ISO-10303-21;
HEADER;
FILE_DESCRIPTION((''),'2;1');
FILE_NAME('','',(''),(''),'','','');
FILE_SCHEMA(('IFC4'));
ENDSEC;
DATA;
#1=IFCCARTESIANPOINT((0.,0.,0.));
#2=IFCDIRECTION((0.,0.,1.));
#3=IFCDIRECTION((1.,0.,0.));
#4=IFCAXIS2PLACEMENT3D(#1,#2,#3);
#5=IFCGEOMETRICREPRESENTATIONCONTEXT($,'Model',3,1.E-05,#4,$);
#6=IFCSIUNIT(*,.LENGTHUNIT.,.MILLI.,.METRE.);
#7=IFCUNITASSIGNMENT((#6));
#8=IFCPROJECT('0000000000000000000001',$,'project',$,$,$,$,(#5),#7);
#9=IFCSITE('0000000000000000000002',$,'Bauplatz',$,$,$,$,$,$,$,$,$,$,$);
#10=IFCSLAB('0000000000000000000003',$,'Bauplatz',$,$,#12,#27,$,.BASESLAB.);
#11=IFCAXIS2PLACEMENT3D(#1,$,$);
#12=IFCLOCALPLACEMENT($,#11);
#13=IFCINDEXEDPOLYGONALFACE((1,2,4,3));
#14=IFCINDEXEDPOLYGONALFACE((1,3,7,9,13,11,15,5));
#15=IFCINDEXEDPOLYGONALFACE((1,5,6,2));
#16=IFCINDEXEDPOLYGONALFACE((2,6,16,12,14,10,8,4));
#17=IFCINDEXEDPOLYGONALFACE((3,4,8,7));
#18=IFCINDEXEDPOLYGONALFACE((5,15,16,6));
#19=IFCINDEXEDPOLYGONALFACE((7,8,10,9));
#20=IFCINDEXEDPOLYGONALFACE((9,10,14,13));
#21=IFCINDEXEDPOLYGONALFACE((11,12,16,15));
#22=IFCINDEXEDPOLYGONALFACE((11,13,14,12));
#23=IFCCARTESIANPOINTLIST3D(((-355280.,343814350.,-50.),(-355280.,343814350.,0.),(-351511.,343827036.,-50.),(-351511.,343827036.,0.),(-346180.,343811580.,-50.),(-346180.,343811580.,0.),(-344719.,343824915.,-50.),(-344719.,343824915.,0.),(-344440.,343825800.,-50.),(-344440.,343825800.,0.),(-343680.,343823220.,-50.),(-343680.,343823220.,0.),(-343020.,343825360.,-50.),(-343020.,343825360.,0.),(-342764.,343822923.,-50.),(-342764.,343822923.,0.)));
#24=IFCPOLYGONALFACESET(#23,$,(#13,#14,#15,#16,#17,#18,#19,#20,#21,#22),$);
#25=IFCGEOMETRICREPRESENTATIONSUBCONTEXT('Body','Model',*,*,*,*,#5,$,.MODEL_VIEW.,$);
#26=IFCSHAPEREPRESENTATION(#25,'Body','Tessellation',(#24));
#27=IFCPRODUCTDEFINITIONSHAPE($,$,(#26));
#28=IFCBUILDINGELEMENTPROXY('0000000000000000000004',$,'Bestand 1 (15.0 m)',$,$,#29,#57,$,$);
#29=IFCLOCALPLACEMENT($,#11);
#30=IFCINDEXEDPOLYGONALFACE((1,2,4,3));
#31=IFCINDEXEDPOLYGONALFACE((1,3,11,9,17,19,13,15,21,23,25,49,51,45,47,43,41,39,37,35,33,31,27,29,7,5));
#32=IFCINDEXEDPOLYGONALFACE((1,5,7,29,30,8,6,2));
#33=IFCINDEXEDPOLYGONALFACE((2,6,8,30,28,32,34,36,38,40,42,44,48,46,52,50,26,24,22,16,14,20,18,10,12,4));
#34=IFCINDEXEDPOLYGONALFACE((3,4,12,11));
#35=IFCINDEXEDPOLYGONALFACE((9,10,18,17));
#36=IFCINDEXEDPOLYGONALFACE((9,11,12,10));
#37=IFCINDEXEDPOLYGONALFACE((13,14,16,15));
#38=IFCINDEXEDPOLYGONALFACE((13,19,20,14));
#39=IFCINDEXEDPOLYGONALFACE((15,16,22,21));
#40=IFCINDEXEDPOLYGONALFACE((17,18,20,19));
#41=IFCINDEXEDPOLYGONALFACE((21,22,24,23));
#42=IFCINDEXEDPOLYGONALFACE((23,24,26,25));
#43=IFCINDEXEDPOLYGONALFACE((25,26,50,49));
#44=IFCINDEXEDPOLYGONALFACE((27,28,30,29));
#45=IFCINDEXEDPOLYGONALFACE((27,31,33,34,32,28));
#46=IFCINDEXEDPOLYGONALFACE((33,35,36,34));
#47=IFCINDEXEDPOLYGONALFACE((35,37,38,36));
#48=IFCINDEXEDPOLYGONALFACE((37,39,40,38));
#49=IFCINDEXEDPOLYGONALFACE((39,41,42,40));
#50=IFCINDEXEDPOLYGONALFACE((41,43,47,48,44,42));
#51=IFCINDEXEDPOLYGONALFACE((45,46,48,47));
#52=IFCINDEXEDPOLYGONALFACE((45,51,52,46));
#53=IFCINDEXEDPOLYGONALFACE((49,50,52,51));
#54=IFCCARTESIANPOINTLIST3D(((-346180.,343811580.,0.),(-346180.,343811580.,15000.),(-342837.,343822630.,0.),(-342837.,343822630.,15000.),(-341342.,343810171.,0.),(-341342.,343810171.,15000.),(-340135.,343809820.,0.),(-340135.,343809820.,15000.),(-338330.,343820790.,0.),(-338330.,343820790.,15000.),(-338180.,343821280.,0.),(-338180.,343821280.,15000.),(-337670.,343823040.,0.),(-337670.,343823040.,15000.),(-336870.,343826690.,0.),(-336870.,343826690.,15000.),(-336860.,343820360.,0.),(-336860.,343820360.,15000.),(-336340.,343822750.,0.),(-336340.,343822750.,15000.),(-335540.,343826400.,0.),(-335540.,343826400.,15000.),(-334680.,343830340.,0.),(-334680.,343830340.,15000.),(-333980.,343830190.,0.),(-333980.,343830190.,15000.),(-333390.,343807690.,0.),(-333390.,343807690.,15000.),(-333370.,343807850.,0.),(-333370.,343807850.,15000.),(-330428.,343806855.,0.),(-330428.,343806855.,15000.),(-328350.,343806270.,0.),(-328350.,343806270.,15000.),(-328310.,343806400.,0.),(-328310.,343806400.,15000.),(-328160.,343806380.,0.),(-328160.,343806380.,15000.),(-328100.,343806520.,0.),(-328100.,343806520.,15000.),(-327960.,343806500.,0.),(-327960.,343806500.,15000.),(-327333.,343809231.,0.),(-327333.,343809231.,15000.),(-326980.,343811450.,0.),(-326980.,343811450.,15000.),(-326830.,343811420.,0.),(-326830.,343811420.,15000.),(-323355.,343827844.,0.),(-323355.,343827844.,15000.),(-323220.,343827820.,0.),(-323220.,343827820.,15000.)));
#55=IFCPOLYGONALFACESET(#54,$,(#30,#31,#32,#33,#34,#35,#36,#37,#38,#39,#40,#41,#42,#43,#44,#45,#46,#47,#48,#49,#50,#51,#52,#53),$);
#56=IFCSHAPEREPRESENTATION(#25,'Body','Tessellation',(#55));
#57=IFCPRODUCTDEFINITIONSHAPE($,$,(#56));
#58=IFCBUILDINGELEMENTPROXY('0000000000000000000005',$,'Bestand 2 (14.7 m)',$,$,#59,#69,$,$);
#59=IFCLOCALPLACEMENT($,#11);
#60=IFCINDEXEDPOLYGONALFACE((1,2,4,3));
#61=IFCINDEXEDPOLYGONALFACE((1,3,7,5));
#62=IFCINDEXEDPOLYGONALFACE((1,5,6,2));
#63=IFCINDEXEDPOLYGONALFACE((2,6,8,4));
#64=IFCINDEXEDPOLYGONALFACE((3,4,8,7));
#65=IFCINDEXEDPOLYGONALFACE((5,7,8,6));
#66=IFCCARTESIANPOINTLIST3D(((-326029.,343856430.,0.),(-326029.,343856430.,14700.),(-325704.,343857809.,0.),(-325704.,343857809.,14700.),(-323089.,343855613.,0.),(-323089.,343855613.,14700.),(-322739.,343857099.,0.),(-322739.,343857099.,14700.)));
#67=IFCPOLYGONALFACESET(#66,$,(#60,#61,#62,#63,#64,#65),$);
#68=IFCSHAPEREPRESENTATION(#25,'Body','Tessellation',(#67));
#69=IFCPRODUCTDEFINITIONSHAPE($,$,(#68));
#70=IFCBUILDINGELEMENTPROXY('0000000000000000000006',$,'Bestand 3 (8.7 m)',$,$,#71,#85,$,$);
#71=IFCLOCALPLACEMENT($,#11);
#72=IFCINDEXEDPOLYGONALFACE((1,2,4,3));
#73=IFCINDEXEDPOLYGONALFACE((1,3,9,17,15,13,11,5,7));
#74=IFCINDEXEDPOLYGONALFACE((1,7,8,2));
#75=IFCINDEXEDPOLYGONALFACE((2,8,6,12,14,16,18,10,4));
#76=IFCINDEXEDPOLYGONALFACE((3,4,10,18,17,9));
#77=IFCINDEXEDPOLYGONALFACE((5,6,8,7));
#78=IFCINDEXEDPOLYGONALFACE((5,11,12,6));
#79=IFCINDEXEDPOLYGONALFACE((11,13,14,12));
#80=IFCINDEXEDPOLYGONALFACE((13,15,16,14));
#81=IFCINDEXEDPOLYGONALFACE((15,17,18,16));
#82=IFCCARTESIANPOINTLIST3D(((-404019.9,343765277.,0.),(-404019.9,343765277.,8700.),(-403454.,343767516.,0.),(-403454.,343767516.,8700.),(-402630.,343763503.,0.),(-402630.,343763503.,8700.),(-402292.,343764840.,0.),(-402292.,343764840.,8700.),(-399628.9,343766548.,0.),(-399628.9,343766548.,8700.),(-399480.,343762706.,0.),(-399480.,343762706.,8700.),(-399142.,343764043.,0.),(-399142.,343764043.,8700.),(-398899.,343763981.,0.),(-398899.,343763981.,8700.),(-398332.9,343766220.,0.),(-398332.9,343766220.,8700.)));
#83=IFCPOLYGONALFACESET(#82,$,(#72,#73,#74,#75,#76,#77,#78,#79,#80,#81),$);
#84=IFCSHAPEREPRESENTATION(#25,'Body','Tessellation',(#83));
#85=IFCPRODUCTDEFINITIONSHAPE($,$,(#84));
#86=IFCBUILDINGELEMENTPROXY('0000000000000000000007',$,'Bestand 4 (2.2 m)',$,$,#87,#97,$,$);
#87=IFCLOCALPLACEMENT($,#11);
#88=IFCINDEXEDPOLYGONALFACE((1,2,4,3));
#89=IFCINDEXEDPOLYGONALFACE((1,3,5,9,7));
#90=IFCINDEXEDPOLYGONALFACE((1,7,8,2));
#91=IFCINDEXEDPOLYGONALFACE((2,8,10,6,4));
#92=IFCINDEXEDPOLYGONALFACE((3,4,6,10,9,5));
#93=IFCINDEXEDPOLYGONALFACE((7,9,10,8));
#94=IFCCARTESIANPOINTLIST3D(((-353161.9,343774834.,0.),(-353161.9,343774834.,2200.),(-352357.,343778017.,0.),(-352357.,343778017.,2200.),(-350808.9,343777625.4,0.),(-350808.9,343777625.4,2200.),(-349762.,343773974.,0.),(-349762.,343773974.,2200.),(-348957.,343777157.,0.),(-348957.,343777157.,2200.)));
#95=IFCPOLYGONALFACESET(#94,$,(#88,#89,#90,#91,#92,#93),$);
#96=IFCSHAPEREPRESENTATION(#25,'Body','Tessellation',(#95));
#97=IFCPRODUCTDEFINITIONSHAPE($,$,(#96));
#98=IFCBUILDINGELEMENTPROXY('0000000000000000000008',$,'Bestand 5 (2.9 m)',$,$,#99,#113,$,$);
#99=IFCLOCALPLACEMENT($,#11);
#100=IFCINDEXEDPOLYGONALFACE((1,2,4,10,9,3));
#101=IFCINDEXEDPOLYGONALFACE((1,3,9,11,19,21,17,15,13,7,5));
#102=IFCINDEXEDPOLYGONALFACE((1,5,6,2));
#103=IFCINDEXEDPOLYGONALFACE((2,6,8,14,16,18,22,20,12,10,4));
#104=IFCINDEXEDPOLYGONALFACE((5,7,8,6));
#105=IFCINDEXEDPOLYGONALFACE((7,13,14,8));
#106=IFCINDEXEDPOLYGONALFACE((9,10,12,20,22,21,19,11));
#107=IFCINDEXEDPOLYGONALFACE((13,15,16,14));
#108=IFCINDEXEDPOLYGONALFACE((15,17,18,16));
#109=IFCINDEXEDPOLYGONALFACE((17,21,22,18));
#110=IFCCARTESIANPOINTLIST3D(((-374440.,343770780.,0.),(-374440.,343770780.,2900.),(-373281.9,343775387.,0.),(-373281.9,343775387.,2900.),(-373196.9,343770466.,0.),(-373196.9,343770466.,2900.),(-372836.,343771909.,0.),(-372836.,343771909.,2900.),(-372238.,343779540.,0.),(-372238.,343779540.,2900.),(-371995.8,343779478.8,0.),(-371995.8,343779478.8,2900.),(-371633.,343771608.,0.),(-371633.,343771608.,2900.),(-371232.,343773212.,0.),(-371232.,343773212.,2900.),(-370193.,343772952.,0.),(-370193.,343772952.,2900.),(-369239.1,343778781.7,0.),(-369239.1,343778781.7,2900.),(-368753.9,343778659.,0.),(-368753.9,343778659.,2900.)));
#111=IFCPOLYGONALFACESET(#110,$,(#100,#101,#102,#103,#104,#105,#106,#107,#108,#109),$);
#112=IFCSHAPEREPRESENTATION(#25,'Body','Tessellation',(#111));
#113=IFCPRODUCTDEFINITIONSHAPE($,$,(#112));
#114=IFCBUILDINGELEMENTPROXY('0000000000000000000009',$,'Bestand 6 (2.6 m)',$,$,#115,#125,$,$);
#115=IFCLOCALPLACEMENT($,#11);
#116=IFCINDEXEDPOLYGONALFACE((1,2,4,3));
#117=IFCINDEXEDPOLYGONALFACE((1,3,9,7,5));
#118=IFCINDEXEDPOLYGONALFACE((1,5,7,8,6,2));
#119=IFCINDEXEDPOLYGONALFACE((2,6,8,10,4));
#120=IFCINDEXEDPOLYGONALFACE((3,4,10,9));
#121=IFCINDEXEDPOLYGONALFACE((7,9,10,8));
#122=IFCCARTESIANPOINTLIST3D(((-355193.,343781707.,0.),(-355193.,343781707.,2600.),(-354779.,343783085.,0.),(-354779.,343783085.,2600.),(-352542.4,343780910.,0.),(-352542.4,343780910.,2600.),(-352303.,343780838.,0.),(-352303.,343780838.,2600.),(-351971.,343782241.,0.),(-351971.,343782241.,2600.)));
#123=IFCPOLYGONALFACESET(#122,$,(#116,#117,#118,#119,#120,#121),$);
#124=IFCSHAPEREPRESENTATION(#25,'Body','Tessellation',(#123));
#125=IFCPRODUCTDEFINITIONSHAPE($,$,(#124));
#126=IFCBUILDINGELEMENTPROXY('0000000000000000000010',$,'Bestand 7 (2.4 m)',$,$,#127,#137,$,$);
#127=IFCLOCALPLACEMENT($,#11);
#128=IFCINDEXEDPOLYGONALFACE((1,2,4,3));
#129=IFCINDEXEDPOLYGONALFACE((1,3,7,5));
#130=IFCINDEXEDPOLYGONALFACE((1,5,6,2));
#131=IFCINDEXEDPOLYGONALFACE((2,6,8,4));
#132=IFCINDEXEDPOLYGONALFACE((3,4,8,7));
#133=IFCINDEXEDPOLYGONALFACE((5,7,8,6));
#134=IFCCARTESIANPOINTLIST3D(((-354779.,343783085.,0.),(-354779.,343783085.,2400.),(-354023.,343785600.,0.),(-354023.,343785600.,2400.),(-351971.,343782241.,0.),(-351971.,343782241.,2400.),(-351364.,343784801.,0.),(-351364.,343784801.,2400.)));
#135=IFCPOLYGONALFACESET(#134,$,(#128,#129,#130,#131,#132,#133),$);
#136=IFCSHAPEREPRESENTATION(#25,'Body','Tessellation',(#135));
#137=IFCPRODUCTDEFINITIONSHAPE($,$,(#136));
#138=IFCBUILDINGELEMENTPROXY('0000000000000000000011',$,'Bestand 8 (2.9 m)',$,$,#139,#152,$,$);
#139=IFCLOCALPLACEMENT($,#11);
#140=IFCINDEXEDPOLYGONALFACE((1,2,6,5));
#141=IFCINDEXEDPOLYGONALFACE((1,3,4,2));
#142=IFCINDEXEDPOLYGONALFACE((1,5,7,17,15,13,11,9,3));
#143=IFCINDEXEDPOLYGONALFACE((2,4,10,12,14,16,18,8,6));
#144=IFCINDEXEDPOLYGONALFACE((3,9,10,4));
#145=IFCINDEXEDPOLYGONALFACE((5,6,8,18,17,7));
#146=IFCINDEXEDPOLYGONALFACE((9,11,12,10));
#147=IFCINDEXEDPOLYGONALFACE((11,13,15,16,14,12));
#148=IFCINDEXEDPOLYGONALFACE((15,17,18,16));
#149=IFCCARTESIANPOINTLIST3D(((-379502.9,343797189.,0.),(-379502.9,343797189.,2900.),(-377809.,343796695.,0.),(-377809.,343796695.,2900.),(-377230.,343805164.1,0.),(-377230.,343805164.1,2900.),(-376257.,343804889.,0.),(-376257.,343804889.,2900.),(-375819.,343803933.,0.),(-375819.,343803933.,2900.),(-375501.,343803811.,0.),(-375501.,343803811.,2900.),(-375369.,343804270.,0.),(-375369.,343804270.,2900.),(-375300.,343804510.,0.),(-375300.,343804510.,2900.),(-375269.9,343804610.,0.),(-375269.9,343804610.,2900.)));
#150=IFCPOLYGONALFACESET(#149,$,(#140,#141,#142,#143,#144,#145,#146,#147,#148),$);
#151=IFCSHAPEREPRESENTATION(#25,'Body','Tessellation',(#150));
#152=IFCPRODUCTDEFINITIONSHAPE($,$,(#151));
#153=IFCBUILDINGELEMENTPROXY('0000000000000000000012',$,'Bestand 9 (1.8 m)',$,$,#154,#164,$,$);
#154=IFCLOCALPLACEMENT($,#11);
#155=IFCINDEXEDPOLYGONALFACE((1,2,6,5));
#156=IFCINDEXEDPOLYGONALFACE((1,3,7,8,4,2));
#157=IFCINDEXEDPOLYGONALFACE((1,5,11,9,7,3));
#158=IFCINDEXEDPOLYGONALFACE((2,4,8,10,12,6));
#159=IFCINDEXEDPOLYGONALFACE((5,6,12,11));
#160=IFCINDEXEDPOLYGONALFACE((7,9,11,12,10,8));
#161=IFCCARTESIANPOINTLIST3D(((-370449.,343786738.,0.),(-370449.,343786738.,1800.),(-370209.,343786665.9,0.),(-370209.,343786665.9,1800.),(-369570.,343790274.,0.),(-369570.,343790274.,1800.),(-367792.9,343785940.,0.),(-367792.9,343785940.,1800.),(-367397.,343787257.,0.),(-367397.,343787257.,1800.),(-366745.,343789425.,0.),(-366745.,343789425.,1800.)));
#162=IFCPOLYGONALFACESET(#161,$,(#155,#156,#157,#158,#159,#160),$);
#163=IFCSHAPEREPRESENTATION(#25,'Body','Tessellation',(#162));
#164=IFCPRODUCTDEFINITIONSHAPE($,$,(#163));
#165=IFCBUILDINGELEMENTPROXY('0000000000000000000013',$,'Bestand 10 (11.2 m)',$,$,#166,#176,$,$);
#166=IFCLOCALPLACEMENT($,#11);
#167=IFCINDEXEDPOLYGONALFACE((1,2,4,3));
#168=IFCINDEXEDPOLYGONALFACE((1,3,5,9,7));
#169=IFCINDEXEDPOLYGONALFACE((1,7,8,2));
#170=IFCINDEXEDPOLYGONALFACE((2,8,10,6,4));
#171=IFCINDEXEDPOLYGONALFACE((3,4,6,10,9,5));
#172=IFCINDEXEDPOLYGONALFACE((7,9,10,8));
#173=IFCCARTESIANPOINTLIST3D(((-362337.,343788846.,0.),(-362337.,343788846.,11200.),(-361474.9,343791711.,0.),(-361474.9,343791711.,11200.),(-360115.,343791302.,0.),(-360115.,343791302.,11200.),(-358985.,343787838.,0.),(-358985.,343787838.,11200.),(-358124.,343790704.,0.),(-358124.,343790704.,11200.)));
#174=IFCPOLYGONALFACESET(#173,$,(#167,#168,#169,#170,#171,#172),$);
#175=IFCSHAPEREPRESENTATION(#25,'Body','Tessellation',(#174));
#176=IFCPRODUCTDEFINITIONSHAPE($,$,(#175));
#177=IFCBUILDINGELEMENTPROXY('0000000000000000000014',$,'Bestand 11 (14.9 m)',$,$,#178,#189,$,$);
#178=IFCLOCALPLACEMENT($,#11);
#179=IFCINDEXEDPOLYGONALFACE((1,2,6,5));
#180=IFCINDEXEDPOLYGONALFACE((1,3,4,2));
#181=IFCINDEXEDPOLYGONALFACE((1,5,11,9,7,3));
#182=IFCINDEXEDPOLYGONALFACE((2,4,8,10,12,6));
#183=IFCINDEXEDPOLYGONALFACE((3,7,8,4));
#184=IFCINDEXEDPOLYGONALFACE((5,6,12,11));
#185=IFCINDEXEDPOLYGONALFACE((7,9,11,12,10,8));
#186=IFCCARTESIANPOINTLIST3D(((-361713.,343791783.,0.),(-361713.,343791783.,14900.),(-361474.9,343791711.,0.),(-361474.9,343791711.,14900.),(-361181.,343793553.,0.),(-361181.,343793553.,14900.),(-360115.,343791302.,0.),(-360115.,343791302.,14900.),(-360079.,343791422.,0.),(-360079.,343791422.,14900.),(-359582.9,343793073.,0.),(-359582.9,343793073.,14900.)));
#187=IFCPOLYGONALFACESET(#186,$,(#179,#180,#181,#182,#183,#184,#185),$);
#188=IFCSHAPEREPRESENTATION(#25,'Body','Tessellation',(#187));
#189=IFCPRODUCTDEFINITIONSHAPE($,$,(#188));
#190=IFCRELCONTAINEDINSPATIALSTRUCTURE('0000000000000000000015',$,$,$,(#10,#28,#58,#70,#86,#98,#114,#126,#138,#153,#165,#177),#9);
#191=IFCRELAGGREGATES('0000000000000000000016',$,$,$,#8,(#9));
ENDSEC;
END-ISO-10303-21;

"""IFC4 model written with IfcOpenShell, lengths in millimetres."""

from ifc_helpers import new_model, si_unit, frame, origin_with_axes, place, context, subcontext, project, spatial, indexed_curve, outline, extrude, element, save


model = new_model("IFC4")

# Units and contexts
model_context = context("Model", 3, precision=1e-05, world=origin_with_axes())
body_context = subcontext(model_context, "Body", "Model", "MODEL_VIEW")
ifc_project = project(units=[si_unit("LENGTHUNIT", "METRE", prefix="MILLI")], contexts=[model_context])

# Site
site = spatial("IfcSite", under=ifc_project, Name="Bauplatz")

# Slab
slab_placement = place(None, frame((0.0, 0.0, -50.0), z_axis=(0.0, 0.0, 1.0), x_axis=(1.0, 0.0, 0.0)))
element("IfcSlab", 1, at=slab_placement, inside=site, Name="Bauplatz", PredefinedType="BASESLAB", context=body_context, shape_type="SweptSolid", body=[
    extrude(outline(indexed_curve([(-355280.0, 343814350.0), (-346180.0, 343811580.0), (-342764.0, 343822923.0), (-343680.0, 343823220.0), (-343020.0, 343825360.0), (-344440.0, 343825800.0), (-344719.0, 343824915.0), (-351511.0, 343827036.0)])), None, (0.0, 0.0, 1.0), 50.0),
])

# Building element proxies
proxy_1_placement = place(None, origin_with_axes())
element("IfcBuildingElementProxy", 2, at=proxy_1_placement, inside=site, Name="Bestand 1 (15.0 m)", context=body_context, shape_type="SweptSolid", body=[
    extrude(outline(indexed_curve([(-333980.0, 343830190.0), (-334680.0, 343830340.0), (-335540.0, 343826400.0), (-336870.0, 343826690.0), (-337670.0, 343823040.0), (-336340.0, 343822750.0), (-336860.0, 343820360.0), (-338330.0, 343820790.0), (-338180.0, 343821280.0), (-342837.0, 343822630.0), (-346180.0, 343811580.0), (-341342.0, 343810171.0), (-340135.0, 343809820.0), (-333370.0, 343807850.0), (-333390.0, 343807690.0), (-330428.0, 343806855.0), (-328350.0, 343806270.0), (-328310.0, 343806400.0), (-328160.0, 343806380.0), (-328100.0, 343806520.0), (-327960.0, 343806500.0), (-327333.0, 343809231.0), (-326830.0, 343811420.0), (-326980.0, 343811450.0), (-323220.0, 343827820.0), (-323355.0, 343827844.0)])), None, (0.0, 0.0, 1.0), 15000.0),
])
proxy_2_placement = place(None, origin_with_axes())
element("IfcBuildingElementProxy", 3, at=proxy_2_placement, inside=site, Name="Bestand 2 (14.7 m)", context=body_context, shape_type="SweptSolid", body=[
    extrude(outline(indexed_curve([(-322739.0, 343857099.0), (-325704.0, 343857809.0), (-326029.0, 343856430.0), (-323089.0, 343855613.0)])), None, (0.0, 0.0, 1.0), 14700.0),
])
proxy_3_placement = place(None, origin_with_axes())
element("IfcBuildingElementProxy", 4, at=proxy_3_placement, inside=site, Name="Bestand 3 (8.7 m)", context=body_context, shape_type="SweptSolid", body=[
    extrude(outline(indexed_curve([(-399628.9, 343766548.0), (-403454.0, 343767516.0), (-404019.9, 343765277.0), (-402292.0, 343764840.0), (-402630.0, 343763503.0), (-399480.0, 343762706.0), (-399142.0, 343764043.0), (-398899.0, 343763981.0), (-398332.9, 343766220.0)])), None, (0.0, 0.0, 1.0), 8700.0),
])
proxy_4_placement = place(None, origin_with_axes())
element("IfcBuildingElementProxy", 5, at=proxy_4_placement, inside=site, Name="Bestand 4 (2.2 m)", context=body_context, shape_type="SweptSolid", body=[
    extrude(outline(indexed_curve([(-350808.9, 343777625.4), (-352357.0, 343778017.0), (-353161.9, 343774834.0), (-349762.0, 343773974.0), (-348957.0, 343777157.0)])), None, (0.0, 0.0, 1.0), 2200.0),
])
proxy_5_placement = place(None, origin_with_axes())
element("IfcBuildingElementProxy", 6, at=proxy_5_placement, inside=site, Name="Bestand 5 (2.9 m)", context=body_context, shape_type="SweptSolid", body=[
    extrude(outline(indexed_curve([(-371995.8, 343779478.8), (-372238.0, 343779540.0), (-373281.9, 343775387.0), (-374440.0, 343770780.0), (-373196.9, 343770466.0), (-372836.0, 343771909.0), (-371633.0, 343771608.0), (-371232.0, 343773212.0), (-370193.0, 343772952.0), (-368753.9, 343778659.0), (-369239.1, 343778781.7)])), None, (0.0, 0.0, 1.0), 2900.0),
])
proxy_6_placement = place(None, origin_with_axes())
element("IfcBuildingElementProxy", 7, at=proxy_6_placement, inside=site, Name="Bestand 6 (2.6 m)", context=body_context, shape_type="SweptSolid", body=[
    extrude(outline(indexed_curve([(-351971.0, 343782241.0), (-354779.0, 343783085.0), (-355193.0, 343781707.0), (-352542.4, 343780910.0), (-352303.0, 343780838.0)])), None, (0.0, 0.0, 1.0), 2600.0),
])
proxy_7_placement = place(None, origin_with_axes())
element("IfcBuildingElementProxy", 8, at=proxy_7_placement, inside=site, Name="Bestand 7 (2.4 m)", context=body_context, shape_type="SweptSolid", body=[
    extrude(outline(indexed_curve([(-351364.0, 343784801.0), (-354023.0, 343785600.0), (-354779.0, 343783085.0), (-351971.0, 343782241.0)])), None, (0.0, 0.0, 1.0), 2400.0),
])
proxy_8_placement = place(None, origin_with_axes())
element("IfcBuildingElementProxy", 9, at=proxy_8_placement, inside=site, Name="Bestand 8 (2.9 m)", context=body_context, shape_type="SweptSolid", body=[
    extrude(outline(indexed_curve([(-376257.0, 343804889.0), (-377230.0, 343805164.1), (-379502.9, 343797189.0), (-377809.0, 343796695.0), (-375819.0, 343803933.0), (-375501.0, 343803811.0), (-375369.0, 343804270.0), (-375300.0, 343804510.0), (-375269.9, 343804610.0)])), None, (0.0, 0.0, 1.0), 2900.0),
])
proxy_9_placement = place(None, origin_with_axes())
element("IfcBuildingElementProxy", 10, at=proxy_9_placement, inside=site, Name="Bestand 9 (1.8 m)", context=body_context, shape_type="SweptSolid", body=[
    extrude(outline(indexed_curve([(-366745.0, 343789425.0), (-369570.0, 343790274.0), (-370449.0, 343786738.0), (-370209.0, 343786665.9), (-367792.9, 343785940.0), (-367397.0, 343787257.0)])), None, (0.0, 0.0, 1.0), 1800.0),
])
proxy_10_placement = place(None, origin_with_axes())
element("IfcBuildingElementProxy", 11, at=proxy_10_placement, inside=site, Name="Bestand 10 (11.2 m)", context=body_context, shape_type="SweptSolid", body=[
    extrude(outline(indexed_curve([(-360115.0, 343791302.0), (-361474.9, 343791711.0), (-362337.0, 343788846.0), (-358985.0, 343787838.0), (-358124.0, 343790704.0)])), None, (0.0, 0.0, 1.0), 11200.0),
])
proxy_11_placement = place(None, origin_with_axes())
element("IfcBuildingElementProxy", 12, at=proxy_11_placement, inside=site, Name="Bestand 11 (14.9 m)", context=body_context, shape_type="SweptSolid", body=[
    extrude(outline(indexed_curve([(-359582.9, 343793073.0), (-361181.0, 343793553.0), (-361713.0, 343791783.0), (-361474.9, 343791711.0), (-360115.0, 343791302.0), (-360079.0, 343791422.0)])), None, (0.0, 0.0, 1.0), 14900.0),
])

save(model, "model.ifc")
